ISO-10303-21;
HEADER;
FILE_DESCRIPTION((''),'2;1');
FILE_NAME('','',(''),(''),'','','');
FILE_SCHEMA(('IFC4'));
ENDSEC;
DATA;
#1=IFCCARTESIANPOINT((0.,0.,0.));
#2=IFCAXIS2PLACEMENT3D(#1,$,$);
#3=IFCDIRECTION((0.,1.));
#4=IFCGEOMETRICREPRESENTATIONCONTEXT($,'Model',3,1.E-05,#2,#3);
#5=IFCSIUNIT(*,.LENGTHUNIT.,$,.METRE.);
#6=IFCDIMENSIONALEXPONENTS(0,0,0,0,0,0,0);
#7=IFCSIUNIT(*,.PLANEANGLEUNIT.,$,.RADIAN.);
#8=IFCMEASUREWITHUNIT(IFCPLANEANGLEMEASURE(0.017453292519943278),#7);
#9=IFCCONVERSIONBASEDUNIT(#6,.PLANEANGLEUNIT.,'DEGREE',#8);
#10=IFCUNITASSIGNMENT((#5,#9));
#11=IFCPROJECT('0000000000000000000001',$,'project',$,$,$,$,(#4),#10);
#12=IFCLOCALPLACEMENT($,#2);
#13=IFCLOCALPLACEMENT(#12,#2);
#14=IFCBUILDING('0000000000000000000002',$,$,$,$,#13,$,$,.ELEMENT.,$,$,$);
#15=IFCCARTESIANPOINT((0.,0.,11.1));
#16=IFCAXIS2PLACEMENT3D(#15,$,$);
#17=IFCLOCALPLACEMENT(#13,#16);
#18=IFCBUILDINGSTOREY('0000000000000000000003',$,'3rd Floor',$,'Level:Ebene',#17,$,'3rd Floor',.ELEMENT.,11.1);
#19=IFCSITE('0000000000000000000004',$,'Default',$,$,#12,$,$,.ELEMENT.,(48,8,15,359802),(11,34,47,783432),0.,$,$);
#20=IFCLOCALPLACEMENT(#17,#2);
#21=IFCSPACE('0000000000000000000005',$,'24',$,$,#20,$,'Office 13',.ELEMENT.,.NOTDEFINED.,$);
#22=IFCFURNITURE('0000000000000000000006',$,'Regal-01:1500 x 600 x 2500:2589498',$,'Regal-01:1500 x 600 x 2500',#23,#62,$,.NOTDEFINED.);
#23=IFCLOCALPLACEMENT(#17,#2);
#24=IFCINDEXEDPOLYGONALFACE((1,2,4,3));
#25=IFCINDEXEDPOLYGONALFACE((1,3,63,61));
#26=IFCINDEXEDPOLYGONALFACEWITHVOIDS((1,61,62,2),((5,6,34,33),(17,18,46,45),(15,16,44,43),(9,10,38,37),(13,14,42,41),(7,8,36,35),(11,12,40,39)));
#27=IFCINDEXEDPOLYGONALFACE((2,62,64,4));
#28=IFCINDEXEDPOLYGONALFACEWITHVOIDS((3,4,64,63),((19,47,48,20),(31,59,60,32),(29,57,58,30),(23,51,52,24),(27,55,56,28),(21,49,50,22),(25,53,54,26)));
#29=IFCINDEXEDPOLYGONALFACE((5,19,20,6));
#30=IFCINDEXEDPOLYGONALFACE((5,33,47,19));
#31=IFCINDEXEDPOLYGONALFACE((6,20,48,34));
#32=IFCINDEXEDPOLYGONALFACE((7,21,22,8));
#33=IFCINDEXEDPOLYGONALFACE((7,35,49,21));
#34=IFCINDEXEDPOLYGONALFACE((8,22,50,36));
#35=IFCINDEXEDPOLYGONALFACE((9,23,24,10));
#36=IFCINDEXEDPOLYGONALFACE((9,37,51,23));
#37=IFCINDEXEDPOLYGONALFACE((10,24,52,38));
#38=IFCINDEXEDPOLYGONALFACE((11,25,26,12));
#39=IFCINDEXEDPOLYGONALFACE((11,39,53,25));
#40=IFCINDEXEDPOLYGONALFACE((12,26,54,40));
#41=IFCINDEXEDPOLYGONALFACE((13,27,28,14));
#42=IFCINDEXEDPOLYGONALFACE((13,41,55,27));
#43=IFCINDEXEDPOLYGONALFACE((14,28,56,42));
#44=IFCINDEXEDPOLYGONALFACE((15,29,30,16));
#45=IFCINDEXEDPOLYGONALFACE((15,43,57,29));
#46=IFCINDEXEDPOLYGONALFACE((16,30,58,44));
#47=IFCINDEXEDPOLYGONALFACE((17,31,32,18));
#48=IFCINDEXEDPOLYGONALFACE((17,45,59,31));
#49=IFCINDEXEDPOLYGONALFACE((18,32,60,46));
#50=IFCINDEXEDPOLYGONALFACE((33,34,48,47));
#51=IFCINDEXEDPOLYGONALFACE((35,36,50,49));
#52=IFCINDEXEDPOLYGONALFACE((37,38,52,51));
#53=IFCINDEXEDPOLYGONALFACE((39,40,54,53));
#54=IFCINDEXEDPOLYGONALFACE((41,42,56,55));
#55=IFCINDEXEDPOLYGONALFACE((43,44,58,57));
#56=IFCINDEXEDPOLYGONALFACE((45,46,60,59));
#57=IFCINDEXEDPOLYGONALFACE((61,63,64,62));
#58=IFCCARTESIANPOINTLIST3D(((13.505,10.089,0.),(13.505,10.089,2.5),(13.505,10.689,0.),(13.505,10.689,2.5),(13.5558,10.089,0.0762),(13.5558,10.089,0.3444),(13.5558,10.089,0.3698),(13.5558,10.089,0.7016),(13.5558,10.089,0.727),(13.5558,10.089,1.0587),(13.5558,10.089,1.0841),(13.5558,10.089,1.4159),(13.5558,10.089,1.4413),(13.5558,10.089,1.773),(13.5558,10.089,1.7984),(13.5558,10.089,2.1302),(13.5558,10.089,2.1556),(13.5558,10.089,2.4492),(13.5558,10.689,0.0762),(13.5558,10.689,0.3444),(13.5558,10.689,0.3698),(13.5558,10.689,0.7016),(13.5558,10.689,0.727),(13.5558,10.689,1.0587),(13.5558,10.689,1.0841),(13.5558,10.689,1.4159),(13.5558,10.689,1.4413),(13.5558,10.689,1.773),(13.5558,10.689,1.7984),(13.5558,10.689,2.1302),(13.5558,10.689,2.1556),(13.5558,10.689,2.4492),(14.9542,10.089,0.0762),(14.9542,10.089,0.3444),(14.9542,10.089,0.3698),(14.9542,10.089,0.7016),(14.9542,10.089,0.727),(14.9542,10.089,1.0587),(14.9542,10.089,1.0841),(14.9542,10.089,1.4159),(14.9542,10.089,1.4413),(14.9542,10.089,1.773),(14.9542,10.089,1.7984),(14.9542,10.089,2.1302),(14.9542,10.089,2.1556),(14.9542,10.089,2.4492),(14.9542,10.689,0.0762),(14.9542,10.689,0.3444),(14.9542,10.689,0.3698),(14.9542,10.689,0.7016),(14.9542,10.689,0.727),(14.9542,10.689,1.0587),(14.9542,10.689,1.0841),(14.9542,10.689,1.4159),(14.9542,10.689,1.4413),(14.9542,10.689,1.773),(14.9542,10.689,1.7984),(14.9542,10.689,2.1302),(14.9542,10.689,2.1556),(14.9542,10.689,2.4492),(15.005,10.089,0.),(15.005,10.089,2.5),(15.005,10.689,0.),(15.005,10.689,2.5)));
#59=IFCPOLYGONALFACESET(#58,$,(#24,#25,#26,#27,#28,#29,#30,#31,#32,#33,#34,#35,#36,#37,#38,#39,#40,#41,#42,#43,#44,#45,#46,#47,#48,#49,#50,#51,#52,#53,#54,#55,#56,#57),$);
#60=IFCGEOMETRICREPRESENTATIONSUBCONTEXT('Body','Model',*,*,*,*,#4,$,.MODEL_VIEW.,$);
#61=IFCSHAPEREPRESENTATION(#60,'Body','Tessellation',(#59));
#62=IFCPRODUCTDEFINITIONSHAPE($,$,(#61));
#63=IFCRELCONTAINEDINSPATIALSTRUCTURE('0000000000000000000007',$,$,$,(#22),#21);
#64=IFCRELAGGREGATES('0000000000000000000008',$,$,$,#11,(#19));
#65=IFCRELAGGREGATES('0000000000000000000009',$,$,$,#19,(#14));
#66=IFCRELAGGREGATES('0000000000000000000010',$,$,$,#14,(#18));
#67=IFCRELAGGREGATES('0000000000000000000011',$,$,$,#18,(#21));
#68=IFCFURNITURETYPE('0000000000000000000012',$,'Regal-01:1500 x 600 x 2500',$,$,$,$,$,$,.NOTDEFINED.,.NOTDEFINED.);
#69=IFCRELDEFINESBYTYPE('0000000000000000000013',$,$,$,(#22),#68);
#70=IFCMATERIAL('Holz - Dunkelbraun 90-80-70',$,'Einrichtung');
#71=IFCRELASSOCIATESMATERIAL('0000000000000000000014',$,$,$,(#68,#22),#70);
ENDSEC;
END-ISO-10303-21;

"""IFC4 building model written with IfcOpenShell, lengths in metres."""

from ifc_helpers import new_model, entity, si_unit, converted_unit, direction, frame, origin, place, context, subcontext, project, spatial, indexed_curve, outline, extrude, source, transform, mapped, material, type_object, type_shapes, element, save


model = new_model("IFC4")

# Units and contexts
model_context = context("Model", 3, precision=1e-05, world=origin(), true_north=direction((0.0, 1.0)))
body_context = subcontext(model_context, "Body", "Model", "MODEL_VIEW")
ifc_project = project(units=[si_unit("LENGTHUNIT", "METRE"), converted_unit("PLANEANGLEUNIT", "DEGREE", entity("IfcPlaneAngleMeasure", 0.017453292519943278), si_unit("PLANEANGLEUNIT", "RADIAN"), dimensions=[0, 0, 0, 0, 0, 0, 0])], contexts=[model_context])

# Site, building, storey
site_placement = place(None, origin())
site = spatial("IfcSite", under=ifc_project, at=site_placement, Name="Default", CompositionType="ELEMENT", RefLatitude=(48, 8, 15, 359802), RefLongitude=(11, 34, 47, 783432), RefElevation=0.0)
building_placement = place(site_placement, origin())
building = spatial("IfcBuilding", under=site, at=building_placement, CompositionType="ELEMENT")
storey_placement = place(building_placement, frame((0.0, 0.0, 11.1)))
storey = spatial("IfcBuildingStorey", under=building, at=storey_placement, Name="3rd Floor", ObjectType="Level:Ebene", LongName="3rd Floor", CompositionType="ELEMENT", Elevation=11.1)

# Shared definitions
ifc_material_1 = material(Name="Holz - Dunkelbraun 90-80-70", Category="Einrichtung")
furniture_type = type_object("IfcFurnitureType", Name="Regal-01:1500 x 600 x 2500", AssemblyPlace="NOTDEFINED", PredefinedType="NOTDEFINED", material=ifc_material_1)
shared_shape = source(origin(), body_context, "Body", "SweptSolid", [
    extrude(outline(indexed_curve([(-0.75, -1.25), (0.75, -1.25), (0.75, 1.25), (-0.75, 1.25), (-0.75, -1.25)], self_intersect=False), holes=[indexed_curve([(-0.6992, 1.1992), (0.6992, 1.1992), (0.6992, 0.9056), (-0.6992, 0.9056), (-0.6992, 1.1992)], self_intersect=False), indexed_curve([(-0.6992, -1.1738), (-0.6992, -0.9056), (0.6992, -0.9056), (0.6992, -1.1738), (-0.6992, -1.1738)], self_intersect=False), indexed_curve([(0.6992, 0.1913), (-0.6992, 0.1913), (-0.6992, 0.523), (0.6992, 0.523), (0.6992, 0.1913)], self_intersect=False), indexed_curve([(0.6992, -0.5484), (0.6992, -0.8802), (-0.6992, -0.8802), (-0.6992, -0.5484), (0.6992, -0.5484)], self_intersect=False), indexed_curve([(-0.6992, 0.8802), (0.6992, 0.8802), (0.6992, 0.5484), (-0.6992, 0.5484), (-0.6992, 0.8802)], self_intersect=False), indexed_curve([(-0.6992, 0.1659), (0.6992, 0.1659), (0.6992, -0.1659), (-0.6992, -0.1659), (-0.6992, 0.1659)], self_intersect=False), indexed_curve([(-0.6992, -0.1913), (0.6992, -0.1913), (0.6992, -0.523), (-0.6992, -0.523), (-0.6992, -0.1913)], self_intersect=False)]), frame((0.0, -0.6048, 1.25), z_axis=(0.0, 1.0, 0.0), x_axis=(-1.0, 0.0, 0.0)), (0.0, 0.0, 1.0), 0.6),
])
type_shapes(furniture_type, [shared_shape])

# Shared definitions
space_1_placement = place(storey_placement, origin())
space_1 = spatial("IfcSpace", under=storey, at=space_1_placement, Name="24", LongName="Office 13", CompositionType="ELEMENT", PredefinedType="NOTDEFINED")

# Furniture
furniture_1_placement = place(space_1_placement, frame((14.255, 10.6938, 0.0)))
element("IfcFurniture", 1, at=furniture_1_placement, inside=space_1, type_object=furniture_type, material=ifc_material_1, Name="Regal-01:1500 x 600 x 2500:2589498", ObjectType="Regal-01:1500 x 600 x 2500", PredefinedType="NOTDEFINED", context=body_context, shape_type="MappedRepresentation", body=[
    mapped(shared_shape, transform((0.0, 0.0, 0.0), scale=1.0)),
])

save(model, "model.ifc")
